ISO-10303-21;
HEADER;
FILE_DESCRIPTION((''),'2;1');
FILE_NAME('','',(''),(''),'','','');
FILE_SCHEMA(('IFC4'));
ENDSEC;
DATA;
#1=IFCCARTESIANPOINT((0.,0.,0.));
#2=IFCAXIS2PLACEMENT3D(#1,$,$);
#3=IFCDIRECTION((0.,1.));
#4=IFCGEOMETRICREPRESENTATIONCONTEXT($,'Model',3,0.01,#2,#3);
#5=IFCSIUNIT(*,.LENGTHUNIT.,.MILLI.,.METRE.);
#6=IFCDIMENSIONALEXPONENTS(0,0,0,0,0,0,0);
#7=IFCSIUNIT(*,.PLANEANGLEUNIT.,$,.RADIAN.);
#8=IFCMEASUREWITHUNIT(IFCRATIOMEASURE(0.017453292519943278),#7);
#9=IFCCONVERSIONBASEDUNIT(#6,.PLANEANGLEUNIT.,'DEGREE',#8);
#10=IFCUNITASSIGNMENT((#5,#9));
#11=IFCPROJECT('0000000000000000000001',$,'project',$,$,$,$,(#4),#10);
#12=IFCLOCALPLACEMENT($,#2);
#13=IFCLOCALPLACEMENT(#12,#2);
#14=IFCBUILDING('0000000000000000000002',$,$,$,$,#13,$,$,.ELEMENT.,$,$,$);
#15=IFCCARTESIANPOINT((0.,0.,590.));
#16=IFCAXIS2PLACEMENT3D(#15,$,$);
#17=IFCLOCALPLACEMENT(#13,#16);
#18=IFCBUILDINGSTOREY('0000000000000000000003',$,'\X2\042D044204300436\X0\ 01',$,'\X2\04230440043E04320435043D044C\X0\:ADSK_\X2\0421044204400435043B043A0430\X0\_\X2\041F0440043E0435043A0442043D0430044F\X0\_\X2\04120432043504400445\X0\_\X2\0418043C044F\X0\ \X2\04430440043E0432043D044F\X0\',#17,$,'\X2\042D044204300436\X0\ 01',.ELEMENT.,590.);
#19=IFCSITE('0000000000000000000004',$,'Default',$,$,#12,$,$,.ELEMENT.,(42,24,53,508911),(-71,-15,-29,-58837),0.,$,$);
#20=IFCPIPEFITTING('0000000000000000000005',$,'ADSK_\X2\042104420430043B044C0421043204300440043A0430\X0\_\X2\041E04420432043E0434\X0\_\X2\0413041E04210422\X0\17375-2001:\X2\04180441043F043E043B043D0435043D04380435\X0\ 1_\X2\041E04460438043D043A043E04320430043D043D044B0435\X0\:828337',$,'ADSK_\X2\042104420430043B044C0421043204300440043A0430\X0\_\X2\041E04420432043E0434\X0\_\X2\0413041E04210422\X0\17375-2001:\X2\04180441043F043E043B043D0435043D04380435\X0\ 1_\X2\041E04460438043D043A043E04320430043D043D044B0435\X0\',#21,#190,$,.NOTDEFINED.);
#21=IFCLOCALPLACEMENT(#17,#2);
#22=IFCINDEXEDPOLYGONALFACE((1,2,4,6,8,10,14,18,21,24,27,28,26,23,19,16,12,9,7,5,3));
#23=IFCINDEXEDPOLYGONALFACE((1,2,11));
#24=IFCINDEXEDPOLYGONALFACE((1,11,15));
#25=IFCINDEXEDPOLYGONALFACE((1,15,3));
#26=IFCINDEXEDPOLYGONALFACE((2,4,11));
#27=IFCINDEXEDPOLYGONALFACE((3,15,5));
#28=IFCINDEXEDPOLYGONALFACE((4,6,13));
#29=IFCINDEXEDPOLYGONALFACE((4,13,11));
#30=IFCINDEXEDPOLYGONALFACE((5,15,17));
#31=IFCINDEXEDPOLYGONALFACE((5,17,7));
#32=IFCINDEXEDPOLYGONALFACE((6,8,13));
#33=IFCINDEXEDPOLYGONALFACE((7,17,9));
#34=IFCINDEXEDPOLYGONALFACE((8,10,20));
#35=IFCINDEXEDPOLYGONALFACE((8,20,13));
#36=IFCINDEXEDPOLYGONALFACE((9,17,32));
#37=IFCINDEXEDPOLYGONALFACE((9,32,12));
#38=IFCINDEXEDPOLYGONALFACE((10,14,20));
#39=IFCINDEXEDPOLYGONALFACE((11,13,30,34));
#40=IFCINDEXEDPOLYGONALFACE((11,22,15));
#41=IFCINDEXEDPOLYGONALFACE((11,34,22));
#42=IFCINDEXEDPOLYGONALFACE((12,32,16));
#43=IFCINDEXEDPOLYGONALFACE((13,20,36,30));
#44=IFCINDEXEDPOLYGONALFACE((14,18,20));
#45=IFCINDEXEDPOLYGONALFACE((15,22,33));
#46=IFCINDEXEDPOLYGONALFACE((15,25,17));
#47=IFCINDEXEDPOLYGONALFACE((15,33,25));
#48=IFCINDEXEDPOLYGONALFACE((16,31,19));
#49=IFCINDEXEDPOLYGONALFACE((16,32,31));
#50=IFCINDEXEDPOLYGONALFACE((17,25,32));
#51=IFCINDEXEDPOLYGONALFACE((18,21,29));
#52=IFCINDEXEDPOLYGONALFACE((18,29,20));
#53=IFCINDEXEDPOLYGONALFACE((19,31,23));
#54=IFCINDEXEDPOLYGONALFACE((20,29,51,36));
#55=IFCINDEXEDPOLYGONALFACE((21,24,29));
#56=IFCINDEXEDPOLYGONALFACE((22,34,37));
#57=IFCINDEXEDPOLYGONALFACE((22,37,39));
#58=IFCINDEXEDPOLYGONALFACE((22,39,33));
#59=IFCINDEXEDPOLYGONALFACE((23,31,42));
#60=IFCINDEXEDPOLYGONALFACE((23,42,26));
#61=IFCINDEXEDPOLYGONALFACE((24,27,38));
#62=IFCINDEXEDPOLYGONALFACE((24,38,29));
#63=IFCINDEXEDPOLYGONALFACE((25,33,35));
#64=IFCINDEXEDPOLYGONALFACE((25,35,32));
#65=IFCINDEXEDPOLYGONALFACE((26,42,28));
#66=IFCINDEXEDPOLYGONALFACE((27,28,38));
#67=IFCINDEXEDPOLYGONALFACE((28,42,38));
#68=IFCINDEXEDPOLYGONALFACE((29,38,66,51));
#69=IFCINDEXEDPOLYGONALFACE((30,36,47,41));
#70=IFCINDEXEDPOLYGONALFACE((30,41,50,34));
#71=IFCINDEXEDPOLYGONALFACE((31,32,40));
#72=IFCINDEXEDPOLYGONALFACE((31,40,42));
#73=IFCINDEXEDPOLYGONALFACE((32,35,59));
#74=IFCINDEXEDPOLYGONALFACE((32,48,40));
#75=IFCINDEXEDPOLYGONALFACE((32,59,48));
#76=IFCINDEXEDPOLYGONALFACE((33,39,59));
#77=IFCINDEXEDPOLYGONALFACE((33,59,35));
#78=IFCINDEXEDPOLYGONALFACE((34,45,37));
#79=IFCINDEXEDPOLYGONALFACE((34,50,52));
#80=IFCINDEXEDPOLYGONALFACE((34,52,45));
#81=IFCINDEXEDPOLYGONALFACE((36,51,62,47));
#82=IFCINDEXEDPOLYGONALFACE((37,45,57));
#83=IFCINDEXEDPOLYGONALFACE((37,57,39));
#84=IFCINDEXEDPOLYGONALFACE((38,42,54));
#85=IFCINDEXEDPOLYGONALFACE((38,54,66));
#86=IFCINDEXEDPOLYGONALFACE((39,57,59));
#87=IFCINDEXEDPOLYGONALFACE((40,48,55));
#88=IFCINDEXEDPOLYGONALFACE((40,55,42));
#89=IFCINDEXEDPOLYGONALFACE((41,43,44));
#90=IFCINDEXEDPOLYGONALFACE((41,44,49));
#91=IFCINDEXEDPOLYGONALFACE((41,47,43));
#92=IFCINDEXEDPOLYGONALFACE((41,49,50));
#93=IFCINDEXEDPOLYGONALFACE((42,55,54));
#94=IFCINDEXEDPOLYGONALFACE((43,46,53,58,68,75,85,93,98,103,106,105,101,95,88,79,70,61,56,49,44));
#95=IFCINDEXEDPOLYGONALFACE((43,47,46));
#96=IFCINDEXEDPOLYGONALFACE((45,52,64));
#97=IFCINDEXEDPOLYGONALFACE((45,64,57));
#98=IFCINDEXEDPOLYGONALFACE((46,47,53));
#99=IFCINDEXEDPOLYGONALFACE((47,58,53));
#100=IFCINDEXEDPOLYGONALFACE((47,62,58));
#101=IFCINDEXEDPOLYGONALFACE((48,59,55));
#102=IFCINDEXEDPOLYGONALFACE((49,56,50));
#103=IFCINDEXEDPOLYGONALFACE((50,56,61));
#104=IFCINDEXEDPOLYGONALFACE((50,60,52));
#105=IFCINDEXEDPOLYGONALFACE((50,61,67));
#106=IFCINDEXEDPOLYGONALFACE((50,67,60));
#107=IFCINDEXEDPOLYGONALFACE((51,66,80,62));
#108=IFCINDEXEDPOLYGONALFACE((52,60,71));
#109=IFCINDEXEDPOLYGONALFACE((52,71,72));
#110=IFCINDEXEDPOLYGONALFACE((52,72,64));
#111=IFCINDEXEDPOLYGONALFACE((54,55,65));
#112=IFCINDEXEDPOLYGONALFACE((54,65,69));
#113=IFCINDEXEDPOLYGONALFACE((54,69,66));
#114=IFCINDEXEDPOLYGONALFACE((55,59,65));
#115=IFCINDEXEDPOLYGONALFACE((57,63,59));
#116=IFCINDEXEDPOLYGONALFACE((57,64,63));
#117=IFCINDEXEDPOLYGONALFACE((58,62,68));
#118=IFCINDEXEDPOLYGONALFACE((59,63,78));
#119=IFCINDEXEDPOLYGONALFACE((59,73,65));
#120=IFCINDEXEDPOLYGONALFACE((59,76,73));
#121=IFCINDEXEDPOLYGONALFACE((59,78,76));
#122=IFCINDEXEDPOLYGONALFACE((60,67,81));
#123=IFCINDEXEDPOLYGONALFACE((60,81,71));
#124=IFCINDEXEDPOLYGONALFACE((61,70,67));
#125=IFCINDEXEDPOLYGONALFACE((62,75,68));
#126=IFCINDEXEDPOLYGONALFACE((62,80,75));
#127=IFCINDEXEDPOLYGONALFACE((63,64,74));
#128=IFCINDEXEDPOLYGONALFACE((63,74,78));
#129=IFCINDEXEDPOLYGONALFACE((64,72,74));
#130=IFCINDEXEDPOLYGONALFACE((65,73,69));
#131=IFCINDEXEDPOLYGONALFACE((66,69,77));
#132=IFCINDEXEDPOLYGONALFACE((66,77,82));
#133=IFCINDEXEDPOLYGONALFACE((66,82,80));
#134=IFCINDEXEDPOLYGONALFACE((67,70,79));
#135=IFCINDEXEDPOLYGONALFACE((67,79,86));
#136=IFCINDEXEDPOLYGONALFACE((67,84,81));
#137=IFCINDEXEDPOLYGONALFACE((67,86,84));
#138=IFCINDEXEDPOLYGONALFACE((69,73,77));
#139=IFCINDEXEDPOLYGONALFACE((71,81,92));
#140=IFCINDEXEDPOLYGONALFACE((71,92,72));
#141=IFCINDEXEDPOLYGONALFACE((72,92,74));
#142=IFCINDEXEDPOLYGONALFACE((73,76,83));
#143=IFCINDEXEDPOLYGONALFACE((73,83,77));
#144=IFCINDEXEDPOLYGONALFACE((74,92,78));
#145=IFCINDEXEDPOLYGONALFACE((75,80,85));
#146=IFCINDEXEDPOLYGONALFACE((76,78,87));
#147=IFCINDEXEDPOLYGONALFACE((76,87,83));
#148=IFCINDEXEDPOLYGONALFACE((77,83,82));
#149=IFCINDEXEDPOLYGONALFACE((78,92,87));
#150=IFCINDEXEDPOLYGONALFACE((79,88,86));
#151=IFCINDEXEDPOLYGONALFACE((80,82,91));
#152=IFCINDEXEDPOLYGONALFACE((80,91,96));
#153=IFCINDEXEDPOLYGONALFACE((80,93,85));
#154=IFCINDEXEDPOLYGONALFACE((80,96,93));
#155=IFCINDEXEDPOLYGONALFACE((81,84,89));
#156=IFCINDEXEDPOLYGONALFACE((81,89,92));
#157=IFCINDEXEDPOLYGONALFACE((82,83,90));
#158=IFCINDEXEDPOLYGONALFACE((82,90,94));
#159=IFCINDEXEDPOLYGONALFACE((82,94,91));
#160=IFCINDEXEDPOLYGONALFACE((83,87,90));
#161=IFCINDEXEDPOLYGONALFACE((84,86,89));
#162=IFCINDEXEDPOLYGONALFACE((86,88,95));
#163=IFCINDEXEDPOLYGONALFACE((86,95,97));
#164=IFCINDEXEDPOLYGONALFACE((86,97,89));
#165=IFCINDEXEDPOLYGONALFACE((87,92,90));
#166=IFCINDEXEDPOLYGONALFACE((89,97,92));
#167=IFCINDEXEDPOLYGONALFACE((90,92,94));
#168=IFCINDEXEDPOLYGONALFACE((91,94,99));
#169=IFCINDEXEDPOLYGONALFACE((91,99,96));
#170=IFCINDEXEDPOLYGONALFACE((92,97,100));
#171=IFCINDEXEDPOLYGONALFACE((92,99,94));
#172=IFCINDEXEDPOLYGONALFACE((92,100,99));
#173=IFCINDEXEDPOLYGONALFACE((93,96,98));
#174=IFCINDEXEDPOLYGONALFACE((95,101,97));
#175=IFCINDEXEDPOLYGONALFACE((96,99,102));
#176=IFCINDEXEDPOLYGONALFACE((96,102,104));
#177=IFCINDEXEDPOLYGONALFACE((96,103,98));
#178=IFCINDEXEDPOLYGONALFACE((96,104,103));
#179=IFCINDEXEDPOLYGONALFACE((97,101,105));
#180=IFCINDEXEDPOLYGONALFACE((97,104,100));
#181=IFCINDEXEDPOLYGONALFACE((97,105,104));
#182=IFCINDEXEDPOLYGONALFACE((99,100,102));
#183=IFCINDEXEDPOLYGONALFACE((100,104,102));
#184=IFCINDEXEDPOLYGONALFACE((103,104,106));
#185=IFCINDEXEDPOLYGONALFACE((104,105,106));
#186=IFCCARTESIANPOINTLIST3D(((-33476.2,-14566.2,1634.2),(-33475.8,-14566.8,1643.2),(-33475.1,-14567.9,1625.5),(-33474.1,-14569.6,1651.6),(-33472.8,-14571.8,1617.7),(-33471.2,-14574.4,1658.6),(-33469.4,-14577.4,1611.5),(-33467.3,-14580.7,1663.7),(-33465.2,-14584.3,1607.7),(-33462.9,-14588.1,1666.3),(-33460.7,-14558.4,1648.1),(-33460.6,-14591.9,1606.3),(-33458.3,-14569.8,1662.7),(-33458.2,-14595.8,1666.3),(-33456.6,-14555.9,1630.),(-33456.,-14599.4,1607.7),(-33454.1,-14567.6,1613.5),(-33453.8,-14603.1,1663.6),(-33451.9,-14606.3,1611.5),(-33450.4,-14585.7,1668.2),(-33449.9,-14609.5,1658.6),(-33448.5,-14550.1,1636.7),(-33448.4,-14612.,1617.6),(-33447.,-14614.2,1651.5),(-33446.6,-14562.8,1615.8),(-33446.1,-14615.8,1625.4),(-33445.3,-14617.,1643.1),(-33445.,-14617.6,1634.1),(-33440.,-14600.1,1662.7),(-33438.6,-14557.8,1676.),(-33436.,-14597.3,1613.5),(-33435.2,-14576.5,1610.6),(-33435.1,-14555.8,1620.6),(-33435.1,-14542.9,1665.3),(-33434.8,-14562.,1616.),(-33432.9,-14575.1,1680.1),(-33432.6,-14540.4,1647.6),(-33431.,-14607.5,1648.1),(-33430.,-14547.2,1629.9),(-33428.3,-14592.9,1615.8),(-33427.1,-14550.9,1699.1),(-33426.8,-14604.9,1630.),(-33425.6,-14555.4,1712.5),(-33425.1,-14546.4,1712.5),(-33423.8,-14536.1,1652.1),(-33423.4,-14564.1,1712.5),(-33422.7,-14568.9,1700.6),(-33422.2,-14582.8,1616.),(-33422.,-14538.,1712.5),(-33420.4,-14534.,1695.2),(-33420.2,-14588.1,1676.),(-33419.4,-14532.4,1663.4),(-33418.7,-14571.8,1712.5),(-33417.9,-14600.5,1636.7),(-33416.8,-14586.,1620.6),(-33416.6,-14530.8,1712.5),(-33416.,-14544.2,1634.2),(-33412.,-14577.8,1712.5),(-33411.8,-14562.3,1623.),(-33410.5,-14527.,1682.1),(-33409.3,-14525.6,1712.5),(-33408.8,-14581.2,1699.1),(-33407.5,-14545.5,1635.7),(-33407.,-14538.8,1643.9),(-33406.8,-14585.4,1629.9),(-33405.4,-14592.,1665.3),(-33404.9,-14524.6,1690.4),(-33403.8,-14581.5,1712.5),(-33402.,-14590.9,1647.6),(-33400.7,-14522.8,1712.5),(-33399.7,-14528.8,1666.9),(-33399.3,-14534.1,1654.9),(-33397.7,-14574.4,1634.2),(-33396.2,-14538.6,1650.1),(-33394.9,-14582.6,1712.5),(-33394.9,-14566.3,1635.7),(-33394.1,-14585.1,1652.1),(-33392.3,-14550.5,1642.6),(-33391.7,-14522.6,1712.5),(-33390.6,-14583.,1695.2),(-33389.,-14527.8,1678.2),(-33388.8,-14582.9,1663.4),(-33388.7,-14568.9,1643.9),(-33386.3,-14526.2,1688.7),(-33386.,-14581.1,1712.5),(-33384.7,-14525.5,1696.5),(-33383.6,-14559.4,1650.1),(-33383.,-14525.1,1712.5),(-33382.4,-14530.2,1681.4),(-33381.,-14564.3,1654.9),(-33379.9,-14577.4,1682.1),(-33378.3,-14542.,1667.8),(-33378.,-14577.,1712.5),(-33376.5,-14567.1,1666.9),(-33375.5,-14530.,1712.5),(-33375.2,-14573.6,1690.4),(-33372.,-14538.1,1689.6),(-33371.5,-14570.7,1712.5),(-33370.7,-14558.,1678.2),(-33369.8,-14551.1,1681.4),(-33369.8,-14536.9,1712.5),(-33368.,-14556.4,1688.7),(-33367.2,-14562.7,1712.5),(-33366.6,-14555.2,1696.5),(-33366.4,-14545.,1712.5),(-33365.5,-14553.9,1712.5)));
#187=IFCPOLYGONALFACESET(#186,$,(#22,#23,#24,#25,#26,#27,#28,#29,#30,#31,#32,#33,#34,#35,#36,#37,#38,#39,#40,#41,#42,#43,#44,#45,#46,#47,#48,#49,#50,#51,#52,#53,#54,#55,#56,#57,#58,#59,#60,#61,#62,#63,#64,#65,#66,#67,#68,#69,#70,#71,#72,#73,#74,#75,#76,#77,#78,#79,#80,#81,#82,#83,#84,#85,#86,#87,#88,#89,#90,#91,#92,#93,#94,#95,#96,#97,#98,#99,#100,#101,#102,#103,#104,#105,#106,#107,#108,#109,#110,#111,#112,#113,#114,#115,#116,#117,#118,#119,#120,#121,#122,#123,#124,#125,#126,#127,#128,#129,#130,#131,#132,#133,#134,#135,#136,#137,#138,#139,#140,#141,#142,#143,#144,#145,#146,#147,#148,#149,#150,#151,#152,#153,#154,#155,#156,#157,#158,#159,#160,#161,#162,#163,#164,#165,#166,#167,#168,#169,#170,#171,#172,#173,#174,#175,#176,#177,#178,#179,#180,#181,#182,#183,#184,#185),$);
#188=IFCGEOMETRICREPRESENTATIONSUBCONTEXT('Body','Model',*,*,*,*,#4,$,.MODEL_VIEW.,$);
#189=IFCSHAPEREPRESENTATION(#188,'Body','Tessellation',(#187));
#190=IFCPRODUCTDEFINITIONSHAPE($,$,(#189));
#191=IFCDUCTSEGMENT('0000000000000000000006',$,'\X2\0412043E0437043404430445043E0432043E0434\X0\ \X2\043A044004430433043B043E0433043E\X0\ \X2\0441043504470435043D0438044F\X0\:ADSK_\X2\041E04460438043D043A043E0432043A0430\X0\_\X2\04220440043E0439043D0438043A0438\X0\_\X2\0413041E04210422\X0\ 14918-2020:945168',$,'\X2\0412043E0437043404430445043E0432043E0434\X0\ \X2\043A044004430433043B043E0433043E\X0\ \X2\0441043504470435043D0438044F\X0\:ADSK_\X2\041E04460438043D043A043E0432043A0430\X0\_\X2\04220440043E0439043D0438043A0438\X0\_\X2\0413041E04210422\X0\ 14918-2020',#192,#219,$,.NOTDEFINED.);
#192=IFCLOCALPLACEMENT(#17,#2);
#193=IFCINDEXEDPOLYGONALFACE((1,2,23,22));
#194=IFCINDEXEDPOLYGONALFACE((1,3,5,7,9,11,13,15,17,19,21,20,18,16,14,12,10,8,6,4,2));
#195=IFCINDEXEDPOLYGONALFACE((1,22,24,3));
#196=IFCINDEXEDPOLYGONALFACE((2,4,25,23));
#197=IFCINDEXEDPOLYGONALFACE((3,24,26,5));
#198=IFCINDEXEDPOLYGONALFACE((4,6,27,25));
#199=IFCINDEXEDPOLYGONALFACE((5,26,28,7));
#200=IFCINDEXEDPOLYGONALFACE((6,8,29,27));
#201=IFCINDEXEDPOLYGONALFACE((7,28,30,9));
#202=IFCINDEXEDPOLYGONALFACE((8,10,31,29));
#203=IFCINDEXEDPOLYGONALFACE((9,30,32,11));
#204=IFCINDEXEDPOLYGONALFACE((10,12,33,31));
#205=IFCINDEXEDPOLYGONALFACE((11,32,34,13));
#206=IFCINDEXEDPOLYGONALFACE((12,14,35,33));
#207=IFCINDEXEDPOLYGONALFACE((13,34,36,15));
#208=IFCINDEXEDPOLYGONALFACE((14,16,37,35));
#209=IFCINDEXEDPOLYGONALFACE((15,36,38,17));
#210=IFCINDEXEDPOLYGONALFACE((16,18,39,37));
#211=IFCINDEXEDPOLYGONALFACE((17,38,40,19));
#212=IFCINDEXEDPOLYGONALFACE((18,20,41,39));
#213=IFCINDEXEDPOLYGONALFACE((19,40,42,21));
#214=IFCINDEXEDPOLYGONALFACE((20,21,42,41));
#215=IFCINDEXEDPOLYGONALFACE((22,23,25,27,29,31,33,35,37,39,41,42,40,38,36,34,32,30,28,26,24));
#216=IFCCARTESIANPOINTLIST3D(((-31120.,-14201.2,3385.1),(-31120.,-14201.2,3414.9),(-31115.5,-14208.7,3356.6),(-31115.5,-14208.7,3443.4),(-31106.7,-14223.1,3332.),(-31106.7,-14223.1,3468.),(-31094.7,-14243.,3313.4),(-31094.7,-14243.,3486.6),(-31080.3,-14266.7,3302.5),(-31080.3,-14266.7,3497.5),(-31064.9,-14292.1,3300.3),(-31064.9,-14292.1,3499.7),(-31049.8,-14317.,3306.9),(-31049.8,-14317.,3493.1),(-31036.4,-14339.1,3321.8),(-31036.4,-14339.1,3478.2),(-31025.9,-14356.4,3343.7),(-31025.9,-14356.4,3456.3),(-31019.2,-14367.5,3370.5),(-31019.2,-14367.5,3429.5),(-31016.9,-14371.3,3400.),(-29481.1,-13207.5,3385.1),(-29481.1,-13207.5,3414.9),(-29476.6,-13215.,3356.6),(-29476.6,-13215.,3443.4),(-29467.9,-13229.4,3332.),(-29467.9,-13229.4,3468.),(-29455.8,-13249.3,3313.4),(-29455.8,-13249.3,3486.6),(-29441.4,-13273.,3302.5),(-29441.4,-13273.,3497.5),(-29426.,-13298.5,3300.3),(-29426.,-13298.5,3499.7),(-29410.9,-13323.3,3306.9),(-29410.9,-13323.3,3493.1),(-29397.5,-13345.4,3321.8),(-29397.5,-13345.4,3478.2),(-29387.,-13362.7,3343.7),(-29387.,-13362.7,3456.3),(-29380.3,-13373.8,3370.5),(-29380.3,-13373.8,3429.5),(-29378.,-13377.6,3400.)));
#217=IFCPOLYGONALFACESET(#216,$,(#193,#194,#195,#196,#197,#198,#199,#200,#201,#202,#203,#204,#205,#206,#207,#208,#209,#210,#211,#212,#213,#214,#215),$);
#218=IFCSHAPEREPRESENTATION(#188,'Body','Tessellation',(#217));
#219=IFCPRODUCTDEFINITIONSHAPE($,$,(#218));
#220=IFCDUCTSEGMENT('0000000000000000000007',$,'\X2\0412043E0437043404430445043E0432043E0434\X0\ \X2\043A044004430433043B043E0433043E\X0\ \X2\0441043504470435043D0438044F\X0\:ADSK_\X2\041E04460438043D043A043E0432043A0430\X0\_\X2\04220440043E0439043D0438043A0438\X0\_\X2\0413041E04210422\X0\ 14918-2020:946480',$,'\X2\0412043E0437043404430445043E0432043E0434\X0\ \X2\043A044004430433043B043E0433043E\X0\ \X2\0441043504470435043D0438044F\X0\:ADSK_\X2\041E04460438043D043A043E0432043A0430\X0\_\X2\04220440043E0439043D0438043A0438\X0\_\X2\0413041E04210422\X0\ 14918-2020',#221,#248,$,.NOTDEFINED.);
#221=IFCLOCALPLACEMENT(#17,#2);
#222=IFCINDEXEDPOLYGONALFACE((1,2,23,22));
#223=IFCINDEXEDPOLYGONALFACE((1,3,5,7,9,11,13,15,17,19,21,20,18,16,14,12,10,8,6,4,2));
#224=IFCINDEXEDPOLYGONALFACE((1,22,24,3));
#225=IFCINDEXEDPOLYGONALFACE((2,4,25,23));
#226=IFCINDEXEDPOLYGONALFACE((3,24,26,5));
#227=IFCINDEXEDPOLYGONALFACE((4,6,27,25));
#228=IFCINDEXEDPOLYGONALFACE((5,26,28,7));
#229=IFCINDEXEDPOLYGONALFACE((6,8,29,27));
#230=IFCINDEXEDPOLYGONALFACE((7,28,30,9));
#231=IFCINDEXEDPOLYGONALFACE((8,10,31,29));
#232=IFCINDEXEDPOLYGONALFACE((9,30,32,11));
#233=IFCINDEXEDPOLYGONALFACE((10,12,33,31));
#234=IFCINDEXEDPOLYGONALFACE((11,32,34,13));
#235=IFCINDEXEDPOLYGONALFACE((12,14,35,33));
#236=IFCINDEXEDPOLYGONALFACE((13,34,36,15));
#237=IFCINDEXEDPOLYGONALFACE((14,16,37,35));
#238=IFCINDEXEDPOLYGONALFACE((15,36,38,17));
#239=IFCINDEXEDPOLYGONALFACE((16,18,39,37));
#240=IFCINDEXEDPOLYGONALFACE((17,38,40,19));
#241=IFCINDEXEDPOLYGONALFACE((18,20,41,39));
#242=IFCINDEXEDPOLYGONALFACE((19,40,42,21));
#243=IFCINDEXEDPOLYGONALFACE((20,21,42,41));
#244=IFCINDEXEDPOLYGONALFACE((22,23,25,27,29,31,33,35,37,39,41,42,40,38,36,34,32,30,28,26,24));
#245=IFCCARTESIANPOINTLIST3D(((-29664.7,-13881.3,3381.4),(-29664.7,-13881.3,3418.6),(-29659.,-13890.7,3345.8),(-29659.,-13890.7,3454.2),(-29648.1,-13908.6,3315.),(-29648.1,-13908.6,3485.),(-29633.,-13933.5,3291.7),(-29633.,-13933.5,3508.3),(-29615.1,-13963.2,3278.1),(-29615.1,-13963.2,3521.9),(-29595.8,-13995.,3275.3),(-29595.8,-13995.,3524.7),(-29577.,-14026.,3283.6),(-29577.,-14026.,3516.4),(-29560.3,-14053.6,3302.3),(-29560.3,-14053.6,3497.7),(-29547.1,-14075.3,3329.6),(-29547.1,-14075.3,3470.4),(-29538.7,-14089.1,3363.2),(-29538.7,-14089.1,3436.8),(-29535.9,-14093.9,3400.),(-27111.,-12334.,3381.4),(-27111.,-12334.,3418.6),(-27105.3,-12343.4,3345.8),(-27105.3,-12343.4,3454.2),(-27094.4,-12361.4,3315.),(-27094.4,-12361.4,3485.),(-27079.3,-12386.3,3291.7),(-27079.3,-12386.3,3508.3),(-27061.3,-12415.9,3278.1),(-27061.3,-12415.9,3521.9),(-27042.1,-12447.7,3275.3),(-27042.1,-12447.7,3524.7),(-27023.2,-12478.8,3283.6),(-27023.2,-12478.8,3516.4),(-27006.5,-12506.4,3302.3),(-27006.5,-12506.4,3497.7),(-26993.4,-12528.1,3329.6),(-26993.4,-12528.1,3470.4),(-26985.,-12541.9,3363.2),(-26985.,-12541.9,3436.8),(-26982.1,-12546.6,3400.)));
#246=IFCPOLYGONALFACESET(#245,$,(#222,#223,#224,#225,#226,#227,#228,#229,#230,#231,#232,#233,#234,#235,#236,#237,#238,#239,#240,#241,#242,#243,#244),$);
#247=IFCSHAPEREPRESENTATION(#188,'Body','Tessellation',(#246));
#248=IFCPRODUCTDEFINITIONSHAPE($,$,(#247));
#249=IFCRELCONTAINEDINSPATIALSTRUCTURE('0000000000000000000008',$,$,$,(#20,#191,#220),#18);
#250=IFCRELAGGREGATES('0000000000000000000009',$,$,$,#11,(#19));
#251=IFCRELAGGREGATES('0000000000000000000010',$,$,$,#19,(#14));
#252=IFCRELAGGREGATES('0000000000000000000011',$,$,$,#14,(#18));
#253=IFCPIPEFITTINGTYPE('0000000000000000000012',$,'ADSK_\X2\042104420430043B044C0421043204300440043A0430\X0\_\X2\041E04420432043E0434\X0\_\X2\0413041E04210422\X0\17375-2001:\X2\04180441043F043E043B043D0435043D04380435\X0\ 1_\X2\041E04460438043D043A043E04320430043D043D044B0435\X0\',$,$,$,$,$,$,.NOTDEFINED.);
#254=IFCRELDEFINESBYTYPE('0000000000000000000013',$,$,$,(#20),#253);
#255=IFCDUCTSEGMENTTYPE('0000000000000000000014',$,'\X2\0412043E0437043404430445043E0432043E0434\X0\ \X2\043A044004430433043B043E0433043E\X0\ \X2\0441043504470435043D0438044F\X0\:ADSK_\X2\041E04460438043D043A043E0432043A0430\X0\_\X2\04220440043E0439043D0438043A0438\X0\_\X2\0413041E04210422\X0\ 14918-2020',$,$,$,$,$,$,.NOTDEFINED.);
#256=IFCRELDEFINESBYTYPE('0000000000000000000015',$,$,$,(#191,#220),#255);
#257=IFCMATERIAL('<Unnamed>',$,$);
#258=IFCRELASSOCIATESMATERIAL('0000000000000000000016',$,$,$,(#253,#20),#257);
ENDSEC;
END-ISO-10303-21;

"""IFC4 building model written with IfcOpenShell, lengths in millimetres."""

from ifc_helpers import new_model, entity, si_unit, converted_unit, direction, frame, origin, origin_2d_with_axis, place, context, subcontext, project, spatial, circle, extrude, source, transform, mapped, material, type_object, type_shapes, element, save


model = new_model("IFC4")

# Units and contexts
model_context = context("Model", 3, precision=0.01, world=origin(), true_north=direction((0.0, 1.0)))
body_context = subcontext(model_context, "Body", "Model", "MODEL_VIEW")
ifc_project = project(units=[si_unit("LENGTHUNIT", "METRE", prefix="MILLI"), converted_unit("PLANEANGLEUNIT", "DEGREE", entity("IfcRatioMeasure", 0.017453292519943278), si_unit("PLANEANGLEUNIT", "RADIAN"), dimensions=[0, 0, 0, 0, 0, 0, 0])], contexts=[model_context])

# Site, building, storey
site_placement = place(None, origin())
site = spatial("IfcSite", under=ifc_project, at=site_placement, Name="Default", CompositionType="ELEMENT", RefLatitude=(42, 24, 53, 508911), RefLongitude=(-71, -15, -29, -58837), RefElevation=0.0)
building_placement = place(site_placement, origin())
building = spatial("IfcBuilding", under=site, at=building_placement, CompositionType="ELEMENT")
storey_placement = place(building_placement, frame((0.0, 0.0, 590.0)))
storey = spatial("IfcBuildingStorey", under=building, at=storey_placement, Name="Этаж 01", ObjectType="Уровень:ADSK_Стрелка_Проектная_Вверх_Имя уровня", LongName="Этаж 01", CompositionType="ELEMENT", Elevation=590.0)

# Shared definitions
ifc_material_1 = material(Name="<Unnamed>")

# Pipe fitting
pipe_fitting_type_1 = type_object("IfcPipeFittingType", Name="ADSK_СтальСварка_Отвод_ГОСТ17375-2001:Исполнение 1_Оцинкованные", PredefinedType="NOTDEFINED", material=ifc_material_1)
ifc_direction_1 = entity("IfcDirection", [0.0, 0.0, 1.0])
trimmed_curve_1 = entity("IfcTrimmedCurve", entity("IfcCircle", entity("IfcAxis2Placement2D", entity("IfcCartesianPoint", [-76.0, 0.0]), entity("IfcDirection", [0.0, 1.0])), 76.0), [entity("IfcParameterValue", 270.0)], [entity("IfcParameterValue", 0.0)], True, "PARAMETER")
shared_shape_1 = source(origin(), body_context, "Body", "AdvancedSweptSolid", [
    entity("IfcSurfaceCurveSweptAreaSolid", entity("IfcCircleProfileDef", "AREA", None, entity("IfcAxis2Placement2D", entity("IfcCartesianPoint", [0.0, 0.0]), entity("IfcDirection", [1.0, 0.0])), 30.1), entity("IfcAxis2Placement3D", entity("IfcCartesianPoint", [-76.0, 0.0, 0.0]), ifc_direction_1, entity("IfcDirection", [0.0, -1.0, 0.0])), trimmed_curve_1, 0.0, 90.0, entity("IfcSurfaceOfLinearExtrusion", entity("IfcArbitraryOpenProfileDef", "CURVE", None, trimmed_curve_1), entity("IfcAxis2Placement3D", entity("IfcCartesianPoint", [0.0, 0.0, -304.8])), ifc_direction_1, 1.0)),
])
type_shapes(pipe_fitting_type_1, [shared_shape_1])
pipe_fitting_1_placement = place(storey_placement, frame((-33395.6, -14552.5, 1636.5), z_axis=(0.51846, -0.855102, 0.0), x_axis=(0.855102, 0.51846, 0.0)))
element("IfcPipeFitting", 1, at=pipe_fitting_1_placement, inside=storey, type_object=pipe_fitting_type_1, material=ifc_material_1, Name="ADSK_СтальСварка_Отвод_ГОСТ17375-2001:Исполнение 1_Оцинкованные:828337", ObjectType="ADSK_СтальСварка_Отвод_ГОСТ17375-2001:Исполнение 1_Оцинкованные", PredefinedType="NOTDEFINED", context=body_context, shape_type="MappedRepresentation", body=[
    mapped(shared_shape_1, transform((0.0, 0.0, 0.0), scale=1.0)),
])

# Duct segments
duct_segment_type = type_object("IfcDuctSegmentType", Name="Воздуховод круглого сечения:ADSK_Оцинковка_Тройники_ГОСТ 14918-2020", PredefinedType="NOTDEFINED")
duct_segment_1_placement = place(storey_placement, frame((-31122.2, -14372.8, 3298.4)))
element("IfcDuctSegment", 2, at=duct_segment_1_placement, inside=storey, type_object=duct_segment_type, Name="Воздуховод круглого сечения:ADSK_Оцинковка_Тройники_ГОСТ 14918-2020:945168", ObjectType="Воздуховод круглого сечения:ADSK_Оцинковка_Тройники_ГОСТ 14918-2020", PredefinedType="NOTDEFINED", context=body_context, shape_type="SweptSolid", body=[
    extrude(circle(Radius=100.0, at=origin_2d_with_axis()), frame((53.4, 87.1, 101.6), z_axis=(0.855102, 0.51846, 0.0), x_axis=(0.51846, -0.855102, 0.0)), (0.0, 0.0, 1.0), 1916.6),
])
duct_segment_2_placement = place(storey_placement, frame((-29667.0, -14095.5, 3273.4)))
element("IfcDuctSegment", 3, at=duct_segment_2_placement, inside=storey, type_object=duct_segment_type, Name="Воздуховод круглого сечения:ADSK_Оцинковка_Тройники_ГОСТ 14918-2020:946480", ObjectType="Воздуховод круглого сечения:ADSK_Оцинковка_Тройники_ГОСТ 14918-2020", PredefinedType="NOTDEFINED", context=body_context, shape_type="SweptSolid", body=[
    extrude(circle(Radius=125.0, at=origin_2d_with_axis()), frame((66.4, 108.5, 126.6), z_axis=(0.855267, 0.518188, 0.0), x_axis=(0.518188, -0.855267, 0.0)), (0.0, 0.0, 1.0), 2985.9),
])

save(model, "model.ifc")
